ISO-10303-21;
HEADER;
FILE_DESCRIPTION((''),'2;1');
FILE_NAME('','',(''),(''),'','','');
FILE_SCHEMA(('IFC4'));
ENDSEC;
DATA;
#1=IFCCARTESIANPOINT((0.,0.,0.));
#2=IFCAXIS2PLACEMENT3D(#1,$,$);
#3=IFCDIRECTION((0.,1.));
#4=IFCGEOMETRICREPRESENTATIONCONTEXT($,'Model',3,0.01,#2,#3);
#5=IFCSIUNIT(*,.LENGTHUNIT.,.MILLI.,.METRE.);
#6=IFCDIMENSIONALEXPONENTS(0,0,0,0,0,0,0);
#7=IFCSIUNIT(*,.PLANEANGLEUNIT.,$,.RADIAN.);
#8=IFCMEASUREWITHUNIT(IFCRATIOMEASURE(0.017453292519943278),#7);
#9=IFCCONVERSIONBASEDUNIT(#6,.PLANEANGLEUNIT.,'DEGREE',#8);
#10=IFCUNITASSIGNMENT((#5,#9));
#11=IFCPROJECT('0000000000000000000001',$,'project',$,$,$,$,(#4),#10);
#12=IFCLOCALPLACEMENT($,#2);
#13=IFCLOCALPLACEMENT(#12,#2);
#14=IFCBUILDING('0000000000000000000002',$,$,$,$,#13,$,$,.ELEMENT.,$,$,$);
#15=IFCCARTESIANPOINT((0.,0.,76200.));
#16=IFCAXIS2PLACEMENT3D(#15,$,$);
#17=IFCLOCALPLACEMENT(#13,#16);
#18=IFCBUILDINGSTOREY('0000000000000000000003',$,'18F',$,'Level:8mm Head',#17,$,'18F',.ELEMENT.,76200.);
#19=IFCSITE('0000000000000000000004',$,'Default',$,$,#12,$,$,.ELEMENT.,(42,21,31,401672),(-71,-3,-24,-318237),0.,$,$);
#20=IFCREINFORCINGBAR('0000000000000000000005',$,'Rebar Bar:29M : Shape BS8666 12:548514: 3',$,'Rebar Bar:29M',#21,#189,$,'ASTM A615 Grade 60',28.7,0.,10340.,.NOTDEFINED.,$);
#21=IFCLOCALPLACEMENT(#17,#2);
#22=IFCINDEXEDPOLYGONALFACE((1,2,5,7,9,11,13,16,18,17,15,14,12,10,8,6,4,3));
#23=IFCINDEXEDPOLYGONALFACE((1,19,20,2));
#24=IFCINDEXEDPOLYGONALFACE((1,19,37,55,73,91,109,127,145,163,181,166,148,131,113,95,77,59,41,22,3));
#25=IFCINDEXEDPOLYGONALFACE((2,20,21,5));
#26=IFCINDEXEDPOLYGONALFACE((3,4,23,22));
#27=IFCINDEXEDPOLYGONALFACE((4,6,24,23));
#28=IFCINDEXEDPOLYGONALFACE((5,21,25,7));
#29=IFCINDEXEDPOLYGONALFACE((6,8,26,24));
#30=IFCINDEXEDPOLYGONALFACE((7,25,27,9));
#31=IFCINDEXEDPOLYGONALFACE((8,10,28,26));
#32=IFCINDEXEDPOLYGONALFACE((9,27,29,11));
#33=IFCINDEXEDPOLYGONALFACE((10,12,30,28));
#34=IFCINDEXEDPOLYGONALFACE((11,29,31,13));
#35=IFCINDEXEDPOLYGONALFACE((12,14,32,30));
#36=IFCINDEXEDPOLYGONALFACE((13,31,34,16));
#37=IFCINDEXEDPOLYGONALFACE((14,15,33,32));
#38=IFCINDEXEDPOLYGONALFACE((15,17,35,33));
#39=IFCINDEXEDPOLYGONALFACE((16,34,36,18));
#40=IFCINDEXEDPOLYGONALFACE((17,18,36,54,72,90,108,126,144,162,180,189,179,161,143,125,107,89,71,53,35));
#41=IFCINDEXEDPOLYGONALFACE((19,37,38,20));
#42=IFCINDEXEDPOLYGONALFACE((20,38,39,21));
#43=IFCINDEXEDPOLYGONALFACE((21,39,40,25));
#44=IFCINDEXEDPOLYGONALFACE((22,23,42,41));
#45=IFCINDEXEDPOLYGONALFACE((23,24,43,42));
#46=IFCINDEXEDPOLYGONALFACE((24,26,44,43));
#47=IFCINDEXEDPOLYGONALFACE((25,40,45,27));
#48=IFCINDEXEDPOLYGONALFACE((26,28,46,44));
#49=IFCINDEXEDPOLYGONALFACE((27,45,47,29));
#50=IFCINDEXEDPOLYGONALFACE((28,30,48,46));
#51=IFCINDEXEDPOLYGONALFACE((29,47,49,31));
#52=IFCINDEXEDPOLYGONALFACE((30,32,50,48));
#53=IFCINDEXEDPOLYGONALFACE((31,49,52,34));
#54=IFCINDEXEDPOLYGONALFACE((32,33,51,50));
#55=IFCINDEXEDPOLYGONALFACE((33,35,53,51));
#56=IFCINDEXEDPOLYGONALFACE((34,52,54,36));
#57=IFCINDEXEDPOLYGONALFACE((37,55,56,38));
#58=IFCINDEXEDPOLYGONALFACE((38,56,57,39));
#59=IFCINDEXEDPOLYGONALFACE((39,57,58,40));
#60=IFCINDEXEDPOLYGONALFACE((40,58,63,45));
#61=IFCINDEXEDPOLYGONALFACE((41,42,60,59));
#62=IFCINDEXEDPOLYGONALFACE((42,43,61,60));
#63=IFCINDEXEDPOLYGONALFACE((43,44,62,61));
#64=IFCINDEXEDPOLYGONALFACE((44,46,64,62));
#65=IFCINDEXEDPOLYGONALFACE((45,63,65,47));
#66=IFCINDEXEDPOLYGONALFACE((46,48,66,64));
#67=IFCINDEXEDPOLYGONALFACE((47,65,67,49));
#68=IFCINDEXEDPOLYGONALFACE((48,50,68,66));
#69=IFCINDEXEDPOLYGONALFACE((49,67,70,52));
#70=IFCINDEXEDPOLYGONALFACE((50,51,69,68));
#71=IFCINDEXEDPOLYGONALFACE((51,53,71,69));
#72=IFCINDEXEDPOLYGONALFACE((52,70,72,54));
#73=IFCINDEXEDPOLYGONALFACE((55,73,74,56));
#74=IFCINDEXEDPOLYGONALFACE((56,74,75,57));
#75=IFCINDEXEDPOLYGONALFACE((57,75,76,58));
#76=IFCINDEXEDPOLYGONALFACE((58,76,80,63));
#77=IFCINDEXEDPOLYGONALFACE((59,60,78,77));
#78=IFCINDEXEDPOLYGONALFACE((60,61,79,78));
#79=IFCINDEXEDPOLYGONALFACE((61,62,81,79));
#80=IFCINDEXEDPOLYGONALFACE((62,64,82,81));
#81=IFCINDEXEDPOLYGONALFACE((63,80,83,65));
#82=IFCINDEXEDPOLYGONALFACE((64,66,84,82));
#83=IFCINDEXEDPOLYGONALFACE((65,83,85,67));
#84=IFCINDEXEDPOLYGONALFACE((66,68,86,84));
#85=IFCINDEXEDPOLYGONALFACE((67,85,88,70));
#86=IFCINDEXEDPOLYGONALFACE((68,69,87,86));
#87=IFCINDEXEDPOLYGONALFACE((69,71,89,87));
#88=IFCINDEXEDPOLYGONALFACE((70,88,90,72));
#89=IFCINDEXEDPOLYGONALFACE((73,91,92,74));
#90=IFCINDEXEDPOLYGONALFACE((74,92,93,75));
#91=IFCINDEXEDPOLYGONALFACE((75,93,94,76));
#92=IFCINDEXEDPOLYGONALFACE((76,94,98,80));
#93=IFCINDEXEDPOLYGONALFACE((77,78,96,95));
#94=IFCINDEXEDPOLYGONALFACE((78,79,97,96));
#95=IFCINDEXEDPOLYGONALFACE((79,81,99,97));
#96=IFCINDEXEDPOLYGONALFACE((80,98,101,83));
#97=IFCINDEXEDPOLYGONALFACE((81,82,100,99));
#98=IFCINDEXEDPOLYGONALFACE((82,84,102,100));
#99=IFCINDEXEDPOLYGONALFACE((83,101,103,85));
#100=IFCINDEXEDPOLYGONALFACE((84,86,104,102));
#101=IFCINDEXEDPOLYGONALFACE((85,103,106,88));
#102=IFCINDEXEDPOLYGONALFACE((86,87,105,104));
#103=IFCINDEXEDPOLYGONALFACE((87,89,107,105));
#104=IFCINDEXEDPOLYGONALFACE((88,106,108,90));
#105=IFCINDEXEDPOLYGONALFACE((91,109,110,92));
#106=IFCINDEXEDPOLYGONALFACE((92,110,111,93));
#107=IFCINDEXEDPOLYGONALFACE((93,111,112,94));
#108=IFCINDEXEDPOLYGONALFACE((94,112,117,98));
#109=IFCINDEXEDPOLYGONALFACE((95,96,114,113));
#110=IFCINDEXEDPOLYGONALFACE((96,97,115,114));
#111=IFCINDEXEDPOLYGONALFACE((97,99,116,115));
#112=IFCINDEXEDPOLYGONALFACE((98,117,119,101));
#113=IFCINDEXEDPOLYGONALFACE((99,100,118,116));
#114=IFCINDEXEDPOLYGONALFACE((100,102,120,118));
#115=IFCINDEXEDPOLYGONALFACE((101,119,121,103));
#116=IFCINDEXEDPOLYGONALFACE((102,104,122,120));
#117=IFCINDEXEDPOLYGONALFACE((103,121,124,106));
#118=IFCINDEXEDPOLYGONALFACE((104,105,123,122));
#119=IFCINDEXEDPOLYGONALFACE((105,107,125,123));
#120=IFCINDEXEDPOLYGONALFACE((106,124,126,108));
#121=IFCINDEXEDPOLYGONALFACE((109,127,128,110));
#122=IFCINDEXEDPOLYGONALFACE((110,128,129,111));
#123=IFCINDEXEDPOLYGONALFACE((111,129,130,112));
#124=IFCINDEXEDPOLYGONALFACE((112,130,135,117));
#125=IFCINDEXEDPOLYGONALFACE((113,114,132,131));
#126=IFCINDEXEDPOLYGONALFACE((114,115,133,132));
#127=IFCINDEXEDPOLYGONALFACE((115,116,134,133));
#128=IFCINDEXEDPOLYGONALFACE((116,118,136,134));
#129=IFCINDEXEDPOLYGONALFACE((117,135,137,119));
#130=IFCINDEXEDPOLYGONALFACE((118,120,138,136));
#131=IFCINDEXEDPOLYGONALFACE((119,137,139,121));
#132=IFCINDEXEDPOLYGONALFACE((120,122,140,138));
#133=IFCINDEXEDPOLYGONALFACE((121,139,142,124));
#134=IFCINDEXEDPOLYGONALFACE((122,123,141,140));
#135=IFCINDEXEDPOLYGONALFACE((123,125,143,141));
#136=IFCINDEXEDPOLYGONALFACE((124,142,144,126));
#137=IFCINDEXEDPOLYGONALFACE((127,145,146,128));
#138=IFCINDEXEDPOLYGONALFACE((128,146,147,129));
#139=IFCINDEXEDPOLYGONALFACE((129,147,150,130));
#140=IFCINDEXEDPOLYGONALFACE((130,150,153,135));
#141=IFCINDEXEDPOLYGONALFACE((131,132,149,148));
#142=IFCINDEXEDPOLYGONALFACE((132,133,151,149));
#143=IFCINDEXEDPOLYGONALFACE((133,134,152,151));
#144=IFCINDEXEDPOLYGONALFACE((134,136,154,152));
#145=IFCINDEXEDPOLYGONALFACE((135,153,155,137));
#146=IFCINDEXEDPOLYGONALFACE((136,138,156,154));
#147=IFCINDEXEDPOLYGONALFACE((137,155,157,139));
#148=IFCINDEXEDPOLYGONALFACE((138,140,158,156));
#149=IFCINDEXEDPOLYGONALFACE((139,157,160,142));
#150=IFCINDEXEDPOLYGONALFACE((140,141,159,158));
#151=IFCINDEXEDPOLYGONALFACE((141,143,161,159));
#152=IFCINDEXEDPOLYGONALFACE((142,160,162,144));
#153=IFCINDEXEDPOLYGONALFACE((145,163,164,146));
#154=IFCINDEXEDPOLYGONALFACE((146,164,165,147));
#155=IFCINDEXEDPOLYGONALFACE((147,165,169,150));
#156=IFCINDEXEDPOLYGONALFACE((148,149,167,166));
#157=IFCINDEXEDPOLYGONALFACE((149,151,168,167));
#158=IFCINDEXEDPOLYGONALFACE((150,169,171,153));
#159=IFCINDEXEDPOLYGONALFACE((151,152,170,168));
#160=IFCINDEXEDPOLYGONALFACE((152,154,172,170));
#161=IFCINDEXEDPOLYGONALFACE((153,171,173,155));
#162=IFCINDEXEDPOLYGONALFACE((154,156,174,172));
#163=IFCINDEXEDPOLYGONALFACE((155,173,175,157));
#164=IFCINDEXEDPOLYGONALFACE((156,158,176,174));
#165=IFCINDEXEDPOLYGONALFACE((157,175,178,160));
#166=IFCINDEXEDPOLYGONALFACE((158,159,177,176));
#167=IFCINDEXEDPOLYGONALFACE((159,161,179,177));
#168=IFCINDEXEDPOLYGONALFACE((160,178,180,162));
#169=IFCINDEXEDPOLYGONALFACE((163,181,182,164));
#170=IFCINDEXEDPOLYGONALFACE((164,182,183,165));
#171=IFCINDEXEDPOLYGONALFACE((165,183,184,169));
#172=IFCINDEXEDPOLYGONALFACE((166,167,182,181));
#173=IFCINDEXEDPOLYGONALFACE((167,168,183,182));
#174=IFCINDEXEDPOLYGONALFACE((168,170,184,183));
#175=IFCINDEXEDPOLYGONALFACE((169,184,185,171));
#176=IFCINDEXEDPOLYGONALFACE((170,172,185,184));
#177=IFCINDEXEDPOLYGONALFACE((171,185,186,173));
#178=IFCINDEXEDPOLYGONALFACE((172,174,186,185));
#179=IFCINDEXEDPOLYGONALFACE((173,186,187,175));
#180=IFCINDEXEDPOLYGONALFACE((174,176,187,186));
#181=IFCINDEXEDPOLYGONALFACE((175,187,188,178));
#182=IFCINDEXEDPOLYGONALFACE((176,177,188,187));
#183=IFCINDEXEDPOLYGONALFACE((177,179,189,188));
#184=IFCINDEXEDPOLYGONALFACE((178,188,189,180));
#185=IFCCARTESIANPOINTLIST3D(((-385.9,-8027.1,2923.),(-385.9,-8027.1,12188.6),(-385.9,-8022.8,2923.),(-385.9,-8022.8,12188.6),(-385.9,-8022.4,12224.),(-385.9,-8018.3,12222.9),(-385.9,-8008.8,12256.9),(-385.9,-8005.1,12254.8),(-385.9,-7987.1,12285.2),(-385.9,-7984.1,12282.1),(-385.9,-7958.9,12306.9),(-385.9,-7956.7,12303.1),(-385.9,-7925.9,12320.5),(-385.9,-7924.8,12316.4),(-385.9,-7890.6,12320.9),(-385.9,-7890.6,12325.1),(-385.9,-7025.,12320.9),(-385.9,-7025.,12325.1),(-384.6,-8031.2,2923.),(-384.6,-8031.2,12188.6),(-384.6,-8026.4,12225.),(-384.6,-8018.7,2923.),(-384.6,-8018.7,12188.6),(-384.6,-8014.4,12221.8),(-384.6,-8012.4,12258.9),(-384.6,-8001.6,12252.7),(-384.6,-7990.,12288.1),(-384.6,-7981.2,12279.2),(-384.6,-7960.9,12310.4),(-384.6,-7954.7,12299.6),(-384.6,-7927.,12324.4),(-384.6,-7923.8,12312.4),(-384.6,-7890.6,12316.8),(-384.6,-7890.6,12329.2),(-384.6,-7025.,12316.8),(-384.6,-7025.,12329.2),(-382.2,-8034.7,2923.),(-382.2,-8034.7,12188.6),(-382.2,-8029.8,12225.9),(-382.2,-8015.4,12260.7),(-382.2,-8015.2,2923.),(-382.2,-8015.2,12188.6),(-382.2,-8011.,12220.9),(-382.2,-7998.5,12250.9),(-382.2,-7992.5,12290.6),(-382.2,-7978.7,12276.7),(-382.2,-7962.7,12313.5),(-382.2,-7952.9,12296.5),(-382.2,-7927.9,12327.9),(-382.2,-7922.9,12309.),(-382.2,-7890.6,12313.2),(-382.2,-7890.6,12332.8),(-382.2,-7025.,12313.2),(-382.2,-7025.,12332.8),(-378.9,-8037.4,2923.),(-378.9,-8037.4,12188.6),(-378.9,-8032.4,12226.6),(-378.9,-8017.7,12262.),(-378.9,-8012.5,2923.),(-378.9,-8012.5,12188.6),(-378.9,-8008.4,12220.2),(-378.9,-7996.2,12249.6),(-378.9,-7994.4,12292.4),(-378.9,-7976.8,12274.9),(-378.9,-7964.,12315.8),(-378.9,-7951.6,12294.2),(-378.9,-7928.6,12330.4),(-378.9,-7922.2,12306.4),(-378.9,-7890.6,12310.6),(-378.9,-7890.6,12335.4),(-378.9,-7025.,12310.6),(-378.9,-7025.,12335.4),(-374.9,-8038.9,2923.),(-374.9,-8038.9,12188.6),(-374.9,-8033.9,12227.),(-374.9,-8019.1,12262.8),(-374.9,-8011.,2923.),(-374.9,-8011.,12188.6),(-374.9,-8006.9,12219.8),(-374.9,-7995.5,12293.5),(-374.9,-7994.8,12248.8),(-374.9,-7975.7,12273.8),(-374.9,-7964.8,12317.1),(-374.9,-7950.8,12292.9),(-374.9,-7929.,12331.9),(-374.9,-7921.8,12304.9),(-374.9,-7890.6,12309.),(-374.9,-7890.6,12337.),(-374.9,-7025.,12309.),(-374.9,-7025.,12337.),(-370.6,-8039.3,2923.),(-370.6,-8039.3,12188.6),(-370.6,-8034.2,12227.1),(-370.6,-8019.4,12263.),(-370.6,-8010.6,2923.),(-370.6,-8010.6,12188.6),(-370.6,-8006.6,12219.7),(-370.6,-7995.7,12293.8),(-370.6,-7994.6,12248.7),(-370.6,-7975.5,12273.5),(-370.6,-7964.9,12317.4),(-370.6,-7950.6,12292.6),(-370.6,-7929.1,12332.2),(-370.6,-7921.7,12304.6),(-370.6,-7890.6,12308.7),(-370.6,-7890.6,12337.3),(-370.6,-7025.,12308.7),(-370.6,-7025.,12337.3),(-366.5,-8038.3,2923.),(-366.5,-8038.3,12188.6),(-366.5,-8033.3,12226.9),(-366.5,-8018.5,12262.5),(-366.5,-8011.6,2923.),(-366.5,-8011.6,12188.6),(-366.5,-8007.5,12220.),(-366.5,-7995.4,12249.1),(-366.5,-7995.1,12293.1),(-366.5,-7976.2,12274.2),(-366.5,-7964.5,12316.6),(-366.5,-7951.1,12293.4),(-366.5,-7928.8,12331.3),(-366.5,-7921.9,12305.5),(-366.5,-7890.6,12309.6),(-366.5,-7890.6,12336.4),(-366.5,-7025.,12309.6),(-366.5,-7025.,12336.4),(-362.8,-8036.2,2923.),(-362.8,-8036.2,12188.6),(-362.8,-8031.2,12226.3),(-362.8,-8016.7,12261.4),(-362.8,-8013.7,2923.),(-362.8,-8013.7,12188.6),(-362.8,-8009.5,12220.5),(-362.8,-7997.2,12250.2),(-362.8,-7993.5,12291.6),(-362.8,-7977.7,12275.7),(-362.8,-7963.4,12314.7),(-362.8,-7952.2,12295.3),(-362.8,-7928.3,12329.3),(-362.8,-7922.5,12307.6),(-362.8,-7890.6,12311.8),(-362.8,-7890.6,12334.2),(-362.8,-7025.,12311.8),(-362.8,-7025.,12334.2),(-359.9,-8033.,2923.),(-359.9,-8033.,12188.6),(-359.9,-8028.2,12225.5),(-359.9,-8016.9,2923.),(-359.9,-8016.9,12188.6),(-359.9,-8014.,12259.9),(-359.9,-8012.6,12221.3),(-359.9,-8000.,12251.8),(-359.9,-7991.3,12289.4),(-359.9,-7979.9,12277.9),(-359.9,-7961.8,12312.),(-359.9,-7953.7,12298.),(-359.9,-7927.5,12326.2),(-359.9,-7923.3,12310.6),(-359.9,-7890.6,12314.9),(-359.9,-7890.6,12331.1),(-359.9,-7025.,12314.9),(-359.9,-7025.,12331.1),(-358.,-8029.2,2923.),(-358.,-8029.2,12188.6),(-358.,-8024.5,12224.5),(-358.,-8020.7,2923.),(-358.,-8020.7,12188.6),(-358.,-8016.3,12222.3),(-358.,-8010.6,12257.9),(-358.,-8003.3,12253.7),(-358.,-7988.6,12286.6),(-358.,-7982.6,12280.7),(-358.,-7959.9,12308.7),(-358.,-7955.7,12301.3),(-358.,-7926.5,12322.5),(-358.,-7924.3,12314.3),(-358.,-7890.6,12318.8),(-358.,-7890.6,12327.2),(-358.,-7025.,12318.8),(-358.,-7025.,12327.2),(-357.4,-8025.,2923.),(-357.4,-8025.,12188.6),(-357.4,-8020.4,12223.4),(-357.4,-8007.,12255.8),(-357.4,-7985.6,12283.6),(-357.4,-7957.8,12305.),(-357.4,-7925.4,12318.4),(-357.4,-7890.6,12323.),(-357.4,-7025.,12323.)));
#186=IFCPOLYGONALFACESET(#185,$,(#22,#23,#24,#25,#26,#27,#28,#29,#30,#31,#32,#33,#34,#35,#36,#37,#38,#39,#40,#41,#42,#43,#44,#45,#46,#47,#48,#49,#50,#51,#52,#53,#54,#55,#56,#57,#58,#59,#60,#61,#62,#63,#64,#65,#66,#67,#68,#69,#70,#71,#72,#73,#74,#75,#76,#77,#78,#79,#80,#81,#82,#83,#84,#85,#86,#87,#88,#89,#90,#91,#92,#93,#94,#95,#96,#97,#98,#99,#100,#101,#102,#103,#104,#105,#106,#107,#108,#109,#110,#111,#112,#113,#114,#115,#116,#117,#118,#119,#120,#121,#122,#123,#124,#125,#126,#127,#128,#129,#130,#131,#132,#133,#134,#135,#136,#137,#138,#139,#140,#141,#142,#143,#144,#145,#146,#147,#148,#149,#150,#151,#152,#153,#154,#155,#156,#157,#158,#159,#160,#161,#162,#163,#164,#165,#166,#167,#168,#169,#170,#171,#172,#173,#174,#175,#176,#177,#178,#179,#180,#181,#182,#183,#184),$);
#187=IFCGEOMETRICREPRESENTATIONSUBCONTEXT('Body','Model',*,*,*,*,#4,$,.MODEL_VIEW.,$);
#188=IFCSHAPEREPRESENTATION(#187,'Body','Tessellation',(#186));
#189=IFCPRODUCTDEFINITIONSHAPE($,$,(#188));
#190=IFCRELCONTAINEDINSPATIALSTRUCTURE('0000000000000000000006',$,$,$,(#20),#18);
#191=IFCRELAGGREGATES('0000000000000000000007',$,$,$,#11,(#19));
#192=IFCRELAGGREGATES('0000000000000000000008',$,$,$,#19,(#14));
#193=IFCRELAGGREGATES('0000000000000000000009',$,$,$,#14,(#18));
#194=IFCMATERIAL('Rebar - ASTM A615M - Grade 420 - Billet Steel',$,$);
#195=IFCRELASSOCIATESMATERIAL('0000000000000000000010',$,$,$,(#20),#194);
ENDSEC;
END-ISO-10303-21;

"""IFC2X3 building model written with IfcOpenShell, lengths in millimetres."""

from ifc_helpers import new_model, entity, si_unit, converted_unit, direction, frame, origin, place, context, subcontext, project, spatial, material, element, save


model = new_model("IFC2X3")

# Units and contexts
model_context = context("Model", 3, precision=0.01, world=origin(), true_north=direction((0.0, 1.0)))
body_context = subcontext(model_context, "Body", "Model", "MODEL_VIEW")
ifc_project = project(units=[si_unit("LENGTHUNIT", "METRE", prefix="MILLI"), converted_unit("PLANEANGLEUNIT", "DEGREE", entity("IfcRatioMeasure", 0.017453292519943278), si_unit("PLANEANGLEUNIT", "RADIAN"), dimensions=[0, 0, 0, 0, 0, 0, 0])], contexts=[model_context])

# Site, building, storey
site_placement = place(None, origin())
site = spatial("IfcSite", under=ifc_project, at=site_placement, Name="Default", CompositionType="ELEMENT", RefLatitude=(42, 21, 31, 401672), RefLongitude=(-71, -3, -24, -318237), RefElevation=0.0)
building_placement = place(site_placement, origin())
building = spatial("IfcBuilding", under=site, at=building_placement, CompositionType="ELEMENT")
storey_placement = place(building_placement, frame((0.0, 0.0, 76200.0)))
storey = spatial("IfcBuildingStorey", under=building, at=storey_placement, Name="18F", ObjectType="Level:8mm Head", LongName="18F", CompositionType="ELEMENT", Elevation=76200.0)

# Reinforcing bar
ifc_material_1 = material(Name="Rebar - ASTM A615M - Grade 420 - Billet Steel")
reinforcing_bar_1_placement = place(storey_placement, origin())
element("IfcReinforcingBar", 1, at=reinforcing_bar_1_placement, inside=storey, material=ifc_material_1, Name="Rebar Bar:29M : Shape BS8666 12:548514: 3", SteelGrade="ASTM A615 Grade 60", ObjectType="Rebar Bar:29M", BarLength=10340.0, BarRole="NOTDEFINED", CrossSectionArea=0.0, NominalDiameter=28.7, context=body_context, shape_type="AdvancedSweptSolid", body=[
    entity("IfcSweptDiskSolid", entity("IfcCompositeCurve", [entity("IfcCompositeCurveSegment", "CONTINUOUS", True, entity("IfcPolyline", [entity("IfcCartesianPoint", [-371.7, -8025.0, 2923.0]), entity("IfcCartesianPoint", [-371.7, -8025.0, 12188.6])])), entity("IfcCompositeCurveSegment", "CONTINUOUS", True, entity("IfcTrimmedCurve", entity("IfcCircle", entity("IfcAxis2Placement3D", entity("IfcCartesianPoint", [-371.7, -7890.6, 12188.6]), entity("IfcDirection", [-1.0, 0.0, 0.0]), entity("IfcDirection", [0.0, 0.0, 1.0])), 134.3), [entity("IfcParameterValue", 270.0)], [entity("IfcParameterValue", 360.0)], True, "PARAMETER")), entity("IfcCompositeCurveSegment", "CONTINUOUS", True, entity("IfcPolyline", [entity("IfcCartesianPoint", [-371.7, -7890.6, 12323.0]), entity("IfcCartesianPoint", [-371.7, -7025.0, 12323.0])]))], False), 14.3, None, 0.0, 92.0),
])

save(model, "model.ifc")
